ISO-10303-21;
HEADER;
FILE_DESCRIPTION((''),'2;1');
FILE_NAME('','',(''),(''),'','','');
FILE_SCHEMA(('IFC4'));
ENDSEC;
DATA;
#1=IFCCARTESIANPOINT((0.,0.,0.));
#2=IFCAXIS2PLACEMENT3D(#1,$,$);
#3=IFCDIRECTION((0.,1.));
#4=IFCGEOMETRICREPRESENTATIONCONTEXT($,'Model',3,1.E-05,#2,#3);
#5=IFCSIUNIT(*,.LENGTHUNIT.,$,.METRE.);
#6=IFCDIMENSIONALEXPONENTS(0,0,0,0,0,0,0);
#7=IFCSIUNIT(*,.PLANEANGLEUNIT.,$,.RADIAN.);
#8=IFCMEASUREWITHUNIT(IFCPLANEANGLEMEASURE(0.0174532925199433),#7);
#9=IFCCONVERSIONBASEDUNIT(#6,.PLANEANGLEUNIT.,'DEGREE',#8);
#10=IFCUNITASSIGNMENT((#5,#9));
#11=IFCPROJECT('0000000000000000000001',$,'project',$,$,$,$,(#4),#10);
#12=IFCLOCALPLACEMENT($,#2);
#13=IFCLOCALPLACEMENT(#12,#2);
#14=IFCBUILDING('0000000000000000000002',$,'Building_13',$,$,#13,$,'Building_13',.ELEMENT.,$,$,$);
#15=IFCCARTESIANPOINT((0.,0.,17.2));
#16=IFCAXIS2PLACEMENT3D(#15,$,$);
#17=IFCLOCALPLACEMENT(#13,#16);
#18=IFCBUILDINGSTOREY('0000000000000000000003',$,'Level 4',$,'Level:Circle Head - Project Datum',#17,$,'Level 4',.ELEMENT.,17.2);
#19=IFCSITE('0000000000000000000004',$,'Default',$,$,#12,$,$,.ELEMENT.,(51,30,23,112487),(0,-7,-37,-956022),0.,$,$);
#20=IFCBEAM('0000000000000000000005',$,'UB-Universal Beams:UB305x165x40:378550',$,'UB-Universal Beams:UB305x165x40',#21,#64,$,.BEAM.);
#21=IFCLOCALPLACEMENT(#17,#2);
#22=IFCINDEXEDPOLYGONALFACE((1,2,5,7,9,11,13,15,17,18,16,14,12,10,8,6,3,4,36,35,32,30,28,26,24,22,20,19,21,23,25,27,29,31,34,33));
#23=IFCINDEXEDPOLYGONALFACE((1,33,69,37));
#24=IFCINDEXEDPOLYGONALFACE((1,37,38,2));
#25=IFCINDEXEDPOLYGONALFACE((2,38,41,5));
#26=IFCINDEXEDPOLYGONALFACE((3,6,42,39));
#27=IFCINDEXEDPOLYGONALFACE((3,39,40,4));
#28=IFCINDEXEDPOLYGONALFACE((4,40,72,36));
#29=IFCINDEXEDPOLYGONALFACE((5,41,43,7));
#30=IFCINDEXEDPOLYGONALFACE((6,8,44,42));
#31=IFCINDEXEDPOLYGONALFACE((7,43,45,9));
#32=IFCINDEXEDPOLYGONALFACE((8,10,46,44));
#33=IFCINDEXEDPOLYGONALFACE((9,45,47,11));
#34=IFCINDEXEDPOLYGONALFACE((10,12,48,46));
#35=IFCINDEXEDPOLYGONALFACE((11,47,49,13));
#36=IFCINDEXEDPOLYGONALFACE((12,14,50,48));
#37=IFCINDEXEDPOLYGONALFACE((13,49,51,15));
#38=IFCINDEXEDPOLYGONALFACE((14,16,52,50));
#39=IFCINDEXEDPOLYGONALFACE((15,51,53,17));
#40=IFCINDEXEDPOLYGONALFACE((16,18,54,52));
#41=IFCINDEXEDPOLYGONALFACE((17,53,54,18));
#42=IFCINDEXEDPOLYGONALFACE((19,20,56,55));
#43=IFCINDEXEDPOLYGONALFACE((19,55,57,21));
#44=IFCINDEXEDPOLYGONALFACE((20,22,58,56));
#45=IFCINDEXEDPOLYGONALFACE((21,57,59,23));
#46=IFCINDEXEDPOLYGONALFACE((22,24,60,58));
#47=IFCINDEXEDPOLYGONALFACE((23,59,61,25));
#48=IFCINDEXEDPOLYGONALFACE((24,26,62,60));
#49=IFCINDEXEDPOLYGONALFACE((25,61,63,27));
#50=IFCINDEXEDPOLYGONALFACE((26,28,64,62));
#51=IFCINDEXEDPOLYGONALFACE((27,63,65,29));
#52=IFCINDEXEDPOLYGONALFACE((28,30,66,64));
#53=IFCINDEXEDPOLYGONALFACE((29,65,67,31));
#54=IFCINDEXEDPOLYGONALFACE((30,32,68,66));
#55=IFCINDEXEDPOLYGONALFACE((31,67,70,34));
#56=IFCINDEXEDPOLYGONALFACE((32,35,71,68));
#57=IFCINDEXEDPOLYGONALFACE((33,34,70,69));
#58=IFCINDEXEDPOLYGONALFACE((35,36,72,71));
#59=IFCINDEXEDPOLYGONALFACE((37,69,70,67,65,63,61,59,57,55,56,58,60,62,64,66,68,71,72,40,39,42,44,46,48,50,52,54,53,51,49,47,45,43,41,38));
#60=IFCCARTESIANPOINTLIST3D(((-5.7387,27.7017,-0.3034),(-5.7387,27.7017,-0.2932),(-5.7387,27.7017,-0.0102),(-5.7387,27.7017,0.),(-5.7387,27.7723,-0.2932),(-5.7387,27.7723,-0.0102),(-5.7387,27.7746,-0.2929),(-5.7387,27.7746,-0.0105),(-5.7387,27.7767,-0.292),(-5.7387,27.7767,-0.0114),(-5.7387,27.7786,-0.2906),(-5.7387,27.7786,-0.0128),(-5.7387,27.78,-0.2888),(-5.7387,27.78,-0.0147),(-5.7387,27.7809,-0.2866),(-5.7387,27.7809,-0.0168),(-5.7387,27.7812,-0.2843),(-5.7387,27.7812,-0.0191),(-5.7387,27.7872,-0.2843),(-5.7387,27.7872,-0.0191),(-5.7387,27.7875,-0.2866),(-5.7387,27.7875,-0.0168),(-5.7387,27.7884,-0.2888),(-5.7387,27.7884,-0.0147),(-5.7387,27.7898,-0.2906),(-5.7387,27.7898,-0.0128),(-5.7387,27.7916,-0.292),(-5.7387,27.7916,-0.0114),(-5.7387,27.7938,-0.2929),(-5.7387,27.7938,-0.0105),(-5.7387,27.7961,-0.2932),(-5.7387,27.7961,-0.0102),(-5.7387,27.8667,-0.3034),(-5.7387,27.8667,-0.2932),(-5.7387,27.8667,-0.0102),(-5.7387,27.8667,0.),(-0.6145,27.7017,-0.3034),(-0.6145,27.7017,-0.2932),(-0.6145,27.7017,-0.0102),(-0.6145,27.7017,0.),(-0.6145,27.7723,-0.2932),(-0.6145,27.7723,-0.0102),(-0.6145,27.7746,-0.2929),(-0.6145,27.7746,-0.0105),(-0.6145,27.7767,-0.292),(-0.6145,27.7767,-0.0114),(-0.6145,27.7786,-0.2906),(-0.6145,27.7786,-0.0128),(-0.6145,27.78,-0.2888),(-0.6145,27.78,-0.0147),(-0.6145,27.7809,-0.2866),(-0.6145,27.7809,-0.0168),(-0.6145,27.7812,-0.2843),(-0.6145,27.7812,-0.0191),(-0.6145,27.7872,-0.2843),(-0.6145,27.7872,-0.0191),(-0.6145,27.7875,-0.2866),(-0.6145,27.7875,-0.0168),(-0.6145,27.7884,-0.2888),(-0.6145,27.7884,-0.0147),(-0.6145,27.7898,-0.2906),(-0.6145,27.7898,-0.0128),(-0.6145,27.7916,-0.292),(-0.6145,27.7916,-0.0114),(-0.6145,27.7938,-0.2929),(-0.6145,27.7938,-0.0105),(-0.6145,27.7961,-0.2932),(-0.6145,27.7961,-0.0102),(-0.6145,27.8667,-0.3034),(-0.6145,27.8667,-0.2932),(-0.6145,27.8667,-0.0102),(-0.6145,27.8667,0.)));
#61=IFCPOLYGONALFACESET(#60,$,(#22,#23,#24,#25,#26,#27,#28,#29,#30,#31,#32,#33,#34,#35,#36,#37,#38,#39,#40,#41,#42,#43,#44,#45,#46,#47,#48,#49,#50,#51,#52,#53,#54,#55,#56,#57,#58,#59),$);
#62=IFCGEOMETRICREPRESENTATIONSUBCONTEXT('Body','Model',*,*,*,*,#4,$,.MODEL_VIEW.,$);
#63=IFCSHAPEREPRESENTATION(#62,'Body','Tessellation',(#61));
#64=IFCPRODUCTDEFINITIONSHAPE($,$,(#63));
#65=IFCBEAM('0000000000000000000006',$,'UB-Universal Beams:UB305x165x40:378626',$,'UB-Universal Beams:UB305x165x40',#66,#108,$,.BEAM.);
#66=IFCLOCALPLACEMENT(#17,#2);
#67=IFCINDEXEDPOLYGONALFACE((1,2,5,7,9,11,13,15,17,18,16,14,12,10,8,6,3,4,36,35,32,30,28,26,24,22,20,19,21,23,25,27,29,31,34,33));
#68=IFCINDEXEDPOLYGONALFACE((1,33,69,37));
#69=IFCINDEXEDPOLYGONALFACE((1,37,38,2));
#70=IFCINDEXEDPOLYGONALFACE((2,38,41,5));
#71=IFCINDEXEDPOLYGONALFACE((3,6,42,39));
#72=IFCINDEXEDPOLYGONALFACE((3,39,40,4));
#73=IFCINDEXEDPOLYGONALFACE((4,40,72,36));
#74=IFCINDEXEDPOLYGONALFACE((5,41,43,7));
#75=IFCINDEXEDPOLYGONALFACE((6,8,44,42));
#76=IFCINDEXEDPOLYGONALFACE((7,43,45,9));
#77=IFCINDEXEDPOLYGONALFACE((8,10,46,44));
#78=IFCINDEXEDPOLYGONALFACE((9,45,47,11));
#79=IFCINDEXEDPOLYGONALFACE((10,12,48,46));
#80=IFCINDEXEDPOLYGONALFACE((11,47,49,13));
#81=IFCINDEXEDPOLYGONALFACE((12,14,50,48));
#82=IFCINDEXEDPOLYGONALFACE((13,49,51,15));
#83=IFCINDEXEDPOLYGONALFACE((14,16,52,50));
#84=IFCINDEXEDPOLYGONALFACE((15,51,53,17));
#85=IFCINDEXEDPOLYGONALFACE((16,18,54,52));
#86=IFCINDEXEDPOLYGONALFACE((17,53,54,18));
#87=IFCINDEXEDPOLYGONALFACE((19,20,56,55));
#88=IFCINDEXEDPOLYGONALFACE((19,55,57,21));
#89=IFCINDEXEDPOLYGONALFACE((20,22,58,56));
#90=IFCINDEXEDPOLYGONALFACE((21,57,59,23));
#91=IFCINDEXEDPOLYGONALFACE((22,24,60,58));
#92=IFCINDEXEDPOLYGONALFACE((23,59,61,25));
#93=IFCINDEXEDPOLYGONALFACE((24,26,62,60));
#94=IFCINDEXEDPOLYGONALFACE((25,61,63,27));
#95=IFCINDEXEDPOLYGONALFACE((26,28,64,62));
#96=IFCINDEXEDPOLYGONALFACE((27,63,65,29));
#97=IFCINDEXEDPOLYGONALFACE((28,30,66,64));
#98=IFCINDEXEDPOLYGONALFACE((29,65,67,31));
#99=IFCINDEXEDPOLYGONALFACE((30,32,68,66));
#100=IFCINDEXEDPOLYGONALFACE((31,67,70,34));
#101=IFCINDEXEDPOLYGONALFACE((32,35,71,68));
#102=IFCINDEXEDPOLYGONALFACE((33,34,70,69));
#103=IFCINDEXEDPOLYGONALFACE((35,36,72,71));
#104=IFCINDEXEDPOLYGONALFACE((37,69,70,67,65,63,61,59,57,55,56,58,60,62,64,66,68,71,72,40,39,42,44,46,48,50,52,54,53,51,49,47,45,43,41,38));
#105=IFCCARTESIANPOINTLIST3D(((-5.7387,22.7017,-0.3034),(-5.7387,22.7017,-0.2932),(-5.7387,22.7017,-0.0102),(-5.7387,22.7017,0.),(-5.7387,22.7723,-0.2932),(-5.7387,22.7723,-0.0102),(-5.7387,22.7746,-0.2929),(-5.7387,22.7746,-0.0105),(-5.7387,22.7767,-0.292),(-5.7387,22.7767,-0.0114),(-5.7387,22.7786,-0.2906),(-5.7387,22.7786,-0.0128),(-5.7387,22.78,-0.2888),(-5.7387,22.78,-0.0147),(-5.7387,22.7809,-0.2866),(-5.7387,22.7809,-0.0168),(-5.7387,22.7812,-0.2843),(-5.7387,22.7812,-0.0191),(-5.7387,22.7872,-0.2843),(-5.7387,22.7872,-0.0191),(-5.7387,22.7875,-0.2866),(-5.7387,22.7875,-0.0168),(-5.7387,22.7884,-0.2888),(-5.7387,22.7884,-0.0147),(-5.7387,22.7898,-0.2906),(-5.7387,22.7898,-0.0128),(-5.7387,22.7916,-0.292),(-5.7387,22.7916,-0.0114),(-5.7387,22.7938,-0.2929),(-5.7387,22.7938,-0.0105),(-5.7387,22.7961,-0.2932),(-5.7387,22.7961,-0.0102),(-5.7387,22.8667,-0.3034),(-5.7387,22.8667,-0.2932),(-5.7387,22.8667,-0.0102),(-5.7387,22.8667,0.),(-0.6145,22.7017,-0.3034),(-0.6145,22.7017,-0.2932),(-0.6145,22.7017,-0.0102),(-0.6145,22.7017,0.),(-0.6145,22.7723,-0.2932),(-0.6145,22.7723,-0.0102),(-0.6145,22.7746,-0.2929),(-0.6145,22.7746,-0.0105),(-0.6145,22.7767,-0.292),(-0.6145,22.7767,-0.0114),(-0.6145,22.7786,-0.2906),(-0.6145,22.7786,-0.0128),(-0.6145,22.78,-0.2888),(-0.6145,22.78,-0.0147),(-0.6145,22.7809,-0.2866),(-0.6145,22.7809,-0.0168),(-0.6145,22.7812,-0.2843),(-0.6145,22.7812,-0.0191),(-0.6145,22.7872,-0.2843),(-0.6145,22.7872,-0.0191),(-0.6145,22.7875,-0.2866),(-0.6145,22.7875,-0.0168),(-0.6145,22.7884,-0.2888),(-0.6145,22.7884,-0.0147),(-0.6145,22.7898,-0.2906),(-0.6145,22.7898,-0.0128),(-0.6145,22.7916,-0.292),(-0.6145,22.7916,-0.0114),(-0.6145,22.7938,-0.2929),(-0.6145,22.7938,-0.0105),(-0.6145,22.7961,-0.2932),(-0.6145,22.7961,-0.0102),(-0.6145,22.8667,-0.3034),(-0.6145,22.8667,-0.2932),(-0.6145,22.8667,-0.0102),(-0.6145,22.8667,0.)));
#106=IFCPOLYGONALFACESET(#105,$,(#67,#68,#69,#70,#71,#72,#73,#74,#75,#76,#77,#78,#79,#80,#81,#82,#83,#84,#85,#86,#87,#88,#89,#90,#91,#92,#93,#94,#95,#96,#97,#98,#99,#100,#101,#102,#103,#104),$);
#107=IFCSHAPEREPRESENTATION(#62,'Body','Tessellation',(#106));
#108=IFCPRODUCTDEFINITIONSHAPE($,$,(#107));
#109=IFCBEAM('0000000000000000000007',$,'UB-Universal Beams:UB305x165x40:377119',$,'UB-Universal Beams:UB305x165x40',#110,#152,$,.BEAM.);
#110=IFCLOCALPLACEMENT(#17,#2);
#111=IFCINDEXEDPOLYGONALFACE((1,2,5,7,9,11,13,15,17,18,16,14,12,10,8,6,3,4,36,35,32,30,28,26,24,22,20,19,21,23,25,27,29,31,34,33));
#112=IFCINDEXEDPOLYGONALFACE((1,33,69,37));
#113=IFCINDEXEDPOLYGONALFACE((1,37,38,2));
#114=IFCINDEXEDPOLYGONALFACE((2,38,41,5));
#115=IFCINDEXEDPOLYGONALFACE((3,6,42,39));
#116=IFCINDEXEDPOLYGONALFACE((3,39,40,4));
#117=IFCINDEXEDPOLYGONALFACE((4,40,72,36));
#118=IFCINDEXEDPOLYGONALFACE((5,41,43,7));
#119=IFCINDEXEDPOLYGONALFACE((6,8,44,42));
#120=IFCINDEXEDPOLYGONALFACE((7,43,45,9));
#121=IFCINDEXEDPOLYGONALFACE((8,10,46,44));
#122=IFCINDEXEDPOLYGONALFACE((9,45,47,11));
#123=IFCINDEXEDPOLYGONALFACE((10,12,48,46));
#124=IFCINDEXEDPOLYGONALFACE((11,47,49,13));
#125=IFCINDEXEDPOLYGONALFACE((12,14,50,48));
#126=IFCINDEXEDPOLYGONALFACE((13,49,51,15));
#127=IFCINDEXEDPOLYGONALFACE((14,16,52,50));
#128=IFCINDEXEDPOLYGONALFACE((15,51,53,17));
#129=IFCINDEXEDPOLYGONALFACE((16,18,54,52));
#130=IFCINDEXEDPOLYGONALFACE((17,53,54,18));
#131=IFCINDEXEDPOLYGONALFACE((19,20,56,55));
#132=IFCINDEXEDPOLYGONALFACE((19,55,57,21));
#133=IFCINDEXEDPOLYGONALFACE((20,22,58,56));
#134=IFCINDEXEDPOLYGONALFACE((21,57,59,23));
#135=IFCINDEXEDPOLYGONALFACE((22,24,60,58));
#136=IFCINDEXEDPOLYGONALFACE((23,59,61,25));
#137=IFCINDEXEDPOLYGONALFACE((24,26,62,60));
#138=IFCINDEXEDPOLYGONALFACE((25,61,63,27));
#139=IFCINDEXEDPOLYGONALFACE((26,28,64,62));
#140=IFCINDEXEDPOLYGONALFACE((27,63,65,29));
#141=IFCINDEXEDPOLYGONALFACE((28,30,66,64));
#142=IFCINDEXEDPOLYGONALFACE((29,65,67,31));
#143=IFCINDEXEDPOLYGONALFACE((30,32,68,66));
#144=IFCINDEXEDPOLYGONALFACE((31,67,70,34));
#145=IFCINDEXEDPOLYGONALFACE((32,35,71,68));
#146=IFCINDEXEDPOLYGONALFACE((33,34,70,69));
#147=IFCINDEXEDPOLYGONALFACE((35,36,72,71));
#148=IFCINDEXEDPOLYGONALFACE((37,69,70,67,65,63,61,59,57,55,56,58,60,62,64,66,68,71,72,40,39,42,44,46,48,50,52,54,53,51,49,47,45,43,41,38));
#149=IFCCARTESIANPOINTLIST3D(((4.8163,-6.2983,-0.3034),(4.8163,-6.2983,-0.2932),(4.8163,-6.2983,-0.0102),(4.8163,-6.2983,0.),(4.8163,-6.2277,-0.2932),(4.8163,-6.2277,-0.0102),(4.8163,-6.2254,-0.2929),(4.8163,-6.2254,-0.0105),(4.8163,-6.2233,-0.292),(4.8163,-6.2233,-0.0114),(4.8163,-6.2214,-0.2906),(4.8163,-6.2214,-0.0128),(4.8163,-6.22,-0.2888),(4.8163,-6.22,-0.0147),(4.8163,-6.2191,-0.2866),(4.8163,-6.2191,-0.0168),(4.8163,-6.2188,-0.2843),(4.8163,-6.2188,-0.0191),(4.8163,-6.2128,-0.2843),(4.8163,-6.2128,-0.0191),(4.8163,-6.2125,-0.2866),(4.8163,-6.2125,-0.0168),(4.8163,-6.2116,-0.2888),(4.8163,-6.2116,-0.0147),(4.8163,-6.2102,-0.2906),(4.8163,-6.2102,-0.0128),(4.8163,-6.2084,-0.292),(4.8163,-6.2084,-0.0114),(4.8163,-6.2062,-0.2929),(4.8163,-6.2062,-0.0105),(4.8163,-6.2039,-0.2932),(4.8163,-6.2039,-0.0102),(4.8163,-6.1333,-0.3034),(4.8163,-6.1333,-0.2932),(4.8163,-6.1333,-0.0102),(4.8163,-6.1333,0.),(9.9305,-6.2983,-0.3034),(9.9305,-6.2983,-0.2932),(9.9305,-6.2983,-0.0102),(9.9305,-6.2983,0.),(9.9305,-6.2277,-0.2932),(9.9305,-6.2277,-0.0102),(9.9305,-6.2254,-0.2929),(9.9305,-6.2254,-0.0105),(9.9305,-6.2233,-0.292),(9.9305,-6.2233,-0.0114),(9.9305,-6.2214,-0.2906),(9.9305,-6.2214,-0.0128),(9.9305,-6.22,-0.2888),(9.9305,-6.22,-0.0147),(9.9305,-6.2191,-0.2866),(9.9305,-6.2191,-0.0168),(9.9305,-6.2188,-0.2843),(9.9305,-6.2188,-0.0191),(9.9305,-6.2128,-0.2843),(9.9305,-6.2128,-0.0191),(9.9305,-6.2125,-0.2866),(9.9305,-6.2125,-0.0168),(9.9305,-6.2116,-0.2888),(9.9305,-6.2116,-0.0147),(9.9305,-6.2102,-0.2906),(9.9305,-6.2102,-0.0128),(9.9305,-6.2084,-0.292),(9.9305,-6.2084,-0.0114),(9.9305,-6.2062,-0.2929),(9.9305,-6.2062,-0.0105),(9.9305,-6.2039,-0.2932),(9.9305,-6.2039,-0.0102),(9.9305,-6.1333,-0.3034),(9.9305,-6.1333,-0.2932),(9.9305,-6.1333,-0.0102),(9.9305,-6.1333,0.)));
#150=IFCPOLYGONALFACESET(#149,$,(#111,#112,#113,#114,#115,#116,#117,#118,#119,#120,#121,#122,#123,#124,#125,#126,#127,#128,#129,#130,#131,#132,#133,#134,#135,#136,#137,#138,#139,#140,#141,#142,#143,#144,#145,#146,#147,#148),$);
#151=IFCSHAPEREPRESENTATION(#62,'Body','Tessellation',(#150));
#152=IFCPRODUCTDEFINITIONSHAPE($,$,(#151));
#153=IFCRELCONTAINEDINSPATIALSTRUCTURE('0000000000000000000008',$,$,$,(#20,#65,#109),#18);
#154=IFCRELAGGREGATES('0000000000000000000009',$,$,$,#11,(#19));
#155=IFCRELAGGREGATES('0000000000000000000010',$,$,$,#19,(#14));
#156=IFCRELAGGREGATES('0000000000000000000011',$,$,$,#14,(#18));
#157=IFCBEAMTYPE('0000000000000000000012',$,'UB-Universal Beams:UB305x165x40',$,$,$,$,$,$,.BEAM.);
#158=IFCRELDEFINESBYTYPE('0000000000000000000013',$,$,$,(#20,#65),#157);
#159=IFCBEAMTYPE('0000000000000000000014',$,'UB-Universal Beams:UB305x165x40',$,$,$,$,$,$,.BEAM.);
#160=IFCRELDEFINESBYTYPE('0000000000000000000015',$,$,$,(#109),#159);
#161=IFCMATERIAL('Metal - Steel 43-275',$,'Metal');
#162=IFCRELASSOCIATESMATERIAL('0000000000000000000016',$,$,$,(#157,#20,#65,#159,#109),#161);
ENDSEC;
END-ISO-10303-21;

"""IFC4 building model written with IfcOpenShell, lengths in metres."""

from ifc_helpers import new_model, entity, si_unit, converted_unit, direction, frame, origin, place, context, subcontext, project, spatial, line, arc, indexed_curve, outline, extrude, source, transform, mapped, material, type_object, type_shapes, element, save


model = new_model("IFC4")

# Units and contexts
model_context = context("Model", 3, precision=1e-05, world=origin(), true_north=direction((0.0, 1.0)))
body_context = subcontext(model_context, "Body", "Model", "MODEL_VIEW")
ifc_project = project(units=[si_unit("LENGTHUNIT", "METRE"), converted_unit("PLANEANGLEUNIT", "DEGREE", entity("IfcPlaneAngleMeasure", 0.0174532925199433), si_unit("PLANEANGLEUNIT", "RADIAN"), dimensions=[0, 0, 0, 0, 0, 0, 0])], contexts=[model_context])

# Site, building, storey
site_placement = place(None, origin())
site = spatial("IfcSite", under=ifc_project, at=site_placement, Name="Default", CompositionType="ELEMENT", RefLatitude=(51, 30, 23, 112487), RefLongitude=(0, -7, -37, -956022), RefElevation=0.0)
building_placement = place(site_placement, origin())
building = spatial("IfcBuilding", under=site, at=building_placement, Name="Building_13", LongName="Building_13", CompositionType="ELEMENT")
storey_placement = place(building_placement, frame((0.0, 0.0, 17.2)))
storey = spatial("IfcBuildingStorey", under=building, at=storey_placement, Name="Level 4", ObjectType="Level:Circle Head - Project Datum", LongName="Level 4", CompositionType="ELEMENT", Elevation=17.2)

# Beams
ifc_material_1 = material(Name="Metal - Steel 43-275", Category="Metal")
beam_type_1 = type_object("IfcBeamType", Name="UB-Universal Beams:UB305x165x40", PredefinedType="BEAM", material=ifc_material_1)
shared_shape_1 = source(origin(), body_context, "Body", "SweptSolid", [
    extrude(outline(indexed_curve([(-0.0825, -0.1415), (-0.0825, -0.1517), (0.0825, -0.1517), (0.0825, -0.1415), (0.0119, -0.1415), (0.0056, -0.1389), (0.003, -0.1326), (0.003, 0.1326), (0.0056, 0.1389), (0.0119, 0.1415), (0.0825, 0.1415), (0.0825, 0.1517), (-0.0825, 0.1517), (-0.0825, 0.1415), (-0.0119, 0.1415), (-0.0056, 0.1389), (-0.003, 0.1326), (-0.003, -0.1326), (-0.0056, -0.1389), (-0.0119, -0.1415)], segments=[line(1, 2, 3, 4, 5), arc(5, 6, 7), line(7, 8), arc(8, 9, 10), line(10, 11, 12, 13, 14, 15), arc(15, 16, 17), line(17, 18), arc(18, 19, 20), line(20, 1)], self_intersect=False)), frame((-2.5621, 0.0, 0.0), z_axis=(-1.0, 0.0, 0.0), x_axis=(0.0, -1.0, 0.0)), (0.0, 0.0, -1.0), 5.1242),
])
type_shapes(beam_type_1, [shared_shape_1])
for number, where, name in (
    (1, (-3.1766, 27.7842, -0.1517), "UB-Universal Beams:UB305x165x40:378550"),
    (2, (-3.1766, 22.7842, -0.1517), "UB-Universal Beams:UB305x165x40:378626"),
):
    element("IfcBeam", number, at=place(storey_placement, frame(where)), inside=storey, type_object=beam_type_1, material=ifc_material_1, Name=name, ObjectType="UB-Universal Beams:UB305x165x40", PredefinedType="BEAM", context=body_context, shape_type="MappedRepresentation", body=[
        mapped(shared_shape_1, transform((0.0, 0.0, 0.0), scale=1.0)),
    ])
beam_type_2 = type_object("IfcBeamType", Name="UB-Universal Beams:UB305x165x40", PredefinedType="BEAM", material=ifc_material_1)
shared_shape_2 = source(origin(), body_context, "Body", "SweptSolid", [
    extrude(outline(indexed_curve([(-0.0825, -0.1415), (-0.0825, -0.1517), (0.0825, -0.1517), (0.0825, -0.1415), (0.0119, -0.1415), (0.0056, -0.1389), (0.003, -0.1326), (0.003, 0.1326), (0.0056, 0.1389), (0.0119, 0.1415), (0.0825, 0.1415), (0.0825, 0.1517), (-0.0825, 0.1517), (-0.0825, 0.1415), (-0.0119, 0.1415), (-0.0056, 0.1389), (-0.003, 0.1326), (-0.003, -0.1326), (-0.0056, -0.1389), (-0.0119, -0.1415)], segments=[line(1, 2, 3, 4, 5), arc(5, 6, 7), line(7, 8), arc(8, 9, 10), line(10, 11, 12, 13, 14, 15), arc(15, 16, 17), line(17, 18), arc(18, 19, 20), line(20, 1)], self_intersect=False)), frame((-2.5571, 0.0, 0.0), z_axis=(-1.0, 0.0, 0.0), x_axis=(0.0, -1.0, 0.0)), (0.0, 0.0, -1.0), 5.1142),
])
type_shapes(beam_type_2, [shared_shape_2])
beam_1_placement = place(storey_placement, frame((7.3734, -6.2158, -0.1517)))
element("IfcBeam", 3, at=beam_1_placement, inside=storey, type_object=beam_type_2, material=ifc_material_1, Name="UB-Universal Beams:UB305x165x40:377119", ObjectType="UB-Universal Beams:UB305x165x40", PredefinedType="BEAM", context=body_context, shape_type="MappedRepresentation", body=[
    mapped(shared_shape_2, transform((0.0, 0.0, 0.0), scale=1.0)),
])

save(model, "model.ifc")
